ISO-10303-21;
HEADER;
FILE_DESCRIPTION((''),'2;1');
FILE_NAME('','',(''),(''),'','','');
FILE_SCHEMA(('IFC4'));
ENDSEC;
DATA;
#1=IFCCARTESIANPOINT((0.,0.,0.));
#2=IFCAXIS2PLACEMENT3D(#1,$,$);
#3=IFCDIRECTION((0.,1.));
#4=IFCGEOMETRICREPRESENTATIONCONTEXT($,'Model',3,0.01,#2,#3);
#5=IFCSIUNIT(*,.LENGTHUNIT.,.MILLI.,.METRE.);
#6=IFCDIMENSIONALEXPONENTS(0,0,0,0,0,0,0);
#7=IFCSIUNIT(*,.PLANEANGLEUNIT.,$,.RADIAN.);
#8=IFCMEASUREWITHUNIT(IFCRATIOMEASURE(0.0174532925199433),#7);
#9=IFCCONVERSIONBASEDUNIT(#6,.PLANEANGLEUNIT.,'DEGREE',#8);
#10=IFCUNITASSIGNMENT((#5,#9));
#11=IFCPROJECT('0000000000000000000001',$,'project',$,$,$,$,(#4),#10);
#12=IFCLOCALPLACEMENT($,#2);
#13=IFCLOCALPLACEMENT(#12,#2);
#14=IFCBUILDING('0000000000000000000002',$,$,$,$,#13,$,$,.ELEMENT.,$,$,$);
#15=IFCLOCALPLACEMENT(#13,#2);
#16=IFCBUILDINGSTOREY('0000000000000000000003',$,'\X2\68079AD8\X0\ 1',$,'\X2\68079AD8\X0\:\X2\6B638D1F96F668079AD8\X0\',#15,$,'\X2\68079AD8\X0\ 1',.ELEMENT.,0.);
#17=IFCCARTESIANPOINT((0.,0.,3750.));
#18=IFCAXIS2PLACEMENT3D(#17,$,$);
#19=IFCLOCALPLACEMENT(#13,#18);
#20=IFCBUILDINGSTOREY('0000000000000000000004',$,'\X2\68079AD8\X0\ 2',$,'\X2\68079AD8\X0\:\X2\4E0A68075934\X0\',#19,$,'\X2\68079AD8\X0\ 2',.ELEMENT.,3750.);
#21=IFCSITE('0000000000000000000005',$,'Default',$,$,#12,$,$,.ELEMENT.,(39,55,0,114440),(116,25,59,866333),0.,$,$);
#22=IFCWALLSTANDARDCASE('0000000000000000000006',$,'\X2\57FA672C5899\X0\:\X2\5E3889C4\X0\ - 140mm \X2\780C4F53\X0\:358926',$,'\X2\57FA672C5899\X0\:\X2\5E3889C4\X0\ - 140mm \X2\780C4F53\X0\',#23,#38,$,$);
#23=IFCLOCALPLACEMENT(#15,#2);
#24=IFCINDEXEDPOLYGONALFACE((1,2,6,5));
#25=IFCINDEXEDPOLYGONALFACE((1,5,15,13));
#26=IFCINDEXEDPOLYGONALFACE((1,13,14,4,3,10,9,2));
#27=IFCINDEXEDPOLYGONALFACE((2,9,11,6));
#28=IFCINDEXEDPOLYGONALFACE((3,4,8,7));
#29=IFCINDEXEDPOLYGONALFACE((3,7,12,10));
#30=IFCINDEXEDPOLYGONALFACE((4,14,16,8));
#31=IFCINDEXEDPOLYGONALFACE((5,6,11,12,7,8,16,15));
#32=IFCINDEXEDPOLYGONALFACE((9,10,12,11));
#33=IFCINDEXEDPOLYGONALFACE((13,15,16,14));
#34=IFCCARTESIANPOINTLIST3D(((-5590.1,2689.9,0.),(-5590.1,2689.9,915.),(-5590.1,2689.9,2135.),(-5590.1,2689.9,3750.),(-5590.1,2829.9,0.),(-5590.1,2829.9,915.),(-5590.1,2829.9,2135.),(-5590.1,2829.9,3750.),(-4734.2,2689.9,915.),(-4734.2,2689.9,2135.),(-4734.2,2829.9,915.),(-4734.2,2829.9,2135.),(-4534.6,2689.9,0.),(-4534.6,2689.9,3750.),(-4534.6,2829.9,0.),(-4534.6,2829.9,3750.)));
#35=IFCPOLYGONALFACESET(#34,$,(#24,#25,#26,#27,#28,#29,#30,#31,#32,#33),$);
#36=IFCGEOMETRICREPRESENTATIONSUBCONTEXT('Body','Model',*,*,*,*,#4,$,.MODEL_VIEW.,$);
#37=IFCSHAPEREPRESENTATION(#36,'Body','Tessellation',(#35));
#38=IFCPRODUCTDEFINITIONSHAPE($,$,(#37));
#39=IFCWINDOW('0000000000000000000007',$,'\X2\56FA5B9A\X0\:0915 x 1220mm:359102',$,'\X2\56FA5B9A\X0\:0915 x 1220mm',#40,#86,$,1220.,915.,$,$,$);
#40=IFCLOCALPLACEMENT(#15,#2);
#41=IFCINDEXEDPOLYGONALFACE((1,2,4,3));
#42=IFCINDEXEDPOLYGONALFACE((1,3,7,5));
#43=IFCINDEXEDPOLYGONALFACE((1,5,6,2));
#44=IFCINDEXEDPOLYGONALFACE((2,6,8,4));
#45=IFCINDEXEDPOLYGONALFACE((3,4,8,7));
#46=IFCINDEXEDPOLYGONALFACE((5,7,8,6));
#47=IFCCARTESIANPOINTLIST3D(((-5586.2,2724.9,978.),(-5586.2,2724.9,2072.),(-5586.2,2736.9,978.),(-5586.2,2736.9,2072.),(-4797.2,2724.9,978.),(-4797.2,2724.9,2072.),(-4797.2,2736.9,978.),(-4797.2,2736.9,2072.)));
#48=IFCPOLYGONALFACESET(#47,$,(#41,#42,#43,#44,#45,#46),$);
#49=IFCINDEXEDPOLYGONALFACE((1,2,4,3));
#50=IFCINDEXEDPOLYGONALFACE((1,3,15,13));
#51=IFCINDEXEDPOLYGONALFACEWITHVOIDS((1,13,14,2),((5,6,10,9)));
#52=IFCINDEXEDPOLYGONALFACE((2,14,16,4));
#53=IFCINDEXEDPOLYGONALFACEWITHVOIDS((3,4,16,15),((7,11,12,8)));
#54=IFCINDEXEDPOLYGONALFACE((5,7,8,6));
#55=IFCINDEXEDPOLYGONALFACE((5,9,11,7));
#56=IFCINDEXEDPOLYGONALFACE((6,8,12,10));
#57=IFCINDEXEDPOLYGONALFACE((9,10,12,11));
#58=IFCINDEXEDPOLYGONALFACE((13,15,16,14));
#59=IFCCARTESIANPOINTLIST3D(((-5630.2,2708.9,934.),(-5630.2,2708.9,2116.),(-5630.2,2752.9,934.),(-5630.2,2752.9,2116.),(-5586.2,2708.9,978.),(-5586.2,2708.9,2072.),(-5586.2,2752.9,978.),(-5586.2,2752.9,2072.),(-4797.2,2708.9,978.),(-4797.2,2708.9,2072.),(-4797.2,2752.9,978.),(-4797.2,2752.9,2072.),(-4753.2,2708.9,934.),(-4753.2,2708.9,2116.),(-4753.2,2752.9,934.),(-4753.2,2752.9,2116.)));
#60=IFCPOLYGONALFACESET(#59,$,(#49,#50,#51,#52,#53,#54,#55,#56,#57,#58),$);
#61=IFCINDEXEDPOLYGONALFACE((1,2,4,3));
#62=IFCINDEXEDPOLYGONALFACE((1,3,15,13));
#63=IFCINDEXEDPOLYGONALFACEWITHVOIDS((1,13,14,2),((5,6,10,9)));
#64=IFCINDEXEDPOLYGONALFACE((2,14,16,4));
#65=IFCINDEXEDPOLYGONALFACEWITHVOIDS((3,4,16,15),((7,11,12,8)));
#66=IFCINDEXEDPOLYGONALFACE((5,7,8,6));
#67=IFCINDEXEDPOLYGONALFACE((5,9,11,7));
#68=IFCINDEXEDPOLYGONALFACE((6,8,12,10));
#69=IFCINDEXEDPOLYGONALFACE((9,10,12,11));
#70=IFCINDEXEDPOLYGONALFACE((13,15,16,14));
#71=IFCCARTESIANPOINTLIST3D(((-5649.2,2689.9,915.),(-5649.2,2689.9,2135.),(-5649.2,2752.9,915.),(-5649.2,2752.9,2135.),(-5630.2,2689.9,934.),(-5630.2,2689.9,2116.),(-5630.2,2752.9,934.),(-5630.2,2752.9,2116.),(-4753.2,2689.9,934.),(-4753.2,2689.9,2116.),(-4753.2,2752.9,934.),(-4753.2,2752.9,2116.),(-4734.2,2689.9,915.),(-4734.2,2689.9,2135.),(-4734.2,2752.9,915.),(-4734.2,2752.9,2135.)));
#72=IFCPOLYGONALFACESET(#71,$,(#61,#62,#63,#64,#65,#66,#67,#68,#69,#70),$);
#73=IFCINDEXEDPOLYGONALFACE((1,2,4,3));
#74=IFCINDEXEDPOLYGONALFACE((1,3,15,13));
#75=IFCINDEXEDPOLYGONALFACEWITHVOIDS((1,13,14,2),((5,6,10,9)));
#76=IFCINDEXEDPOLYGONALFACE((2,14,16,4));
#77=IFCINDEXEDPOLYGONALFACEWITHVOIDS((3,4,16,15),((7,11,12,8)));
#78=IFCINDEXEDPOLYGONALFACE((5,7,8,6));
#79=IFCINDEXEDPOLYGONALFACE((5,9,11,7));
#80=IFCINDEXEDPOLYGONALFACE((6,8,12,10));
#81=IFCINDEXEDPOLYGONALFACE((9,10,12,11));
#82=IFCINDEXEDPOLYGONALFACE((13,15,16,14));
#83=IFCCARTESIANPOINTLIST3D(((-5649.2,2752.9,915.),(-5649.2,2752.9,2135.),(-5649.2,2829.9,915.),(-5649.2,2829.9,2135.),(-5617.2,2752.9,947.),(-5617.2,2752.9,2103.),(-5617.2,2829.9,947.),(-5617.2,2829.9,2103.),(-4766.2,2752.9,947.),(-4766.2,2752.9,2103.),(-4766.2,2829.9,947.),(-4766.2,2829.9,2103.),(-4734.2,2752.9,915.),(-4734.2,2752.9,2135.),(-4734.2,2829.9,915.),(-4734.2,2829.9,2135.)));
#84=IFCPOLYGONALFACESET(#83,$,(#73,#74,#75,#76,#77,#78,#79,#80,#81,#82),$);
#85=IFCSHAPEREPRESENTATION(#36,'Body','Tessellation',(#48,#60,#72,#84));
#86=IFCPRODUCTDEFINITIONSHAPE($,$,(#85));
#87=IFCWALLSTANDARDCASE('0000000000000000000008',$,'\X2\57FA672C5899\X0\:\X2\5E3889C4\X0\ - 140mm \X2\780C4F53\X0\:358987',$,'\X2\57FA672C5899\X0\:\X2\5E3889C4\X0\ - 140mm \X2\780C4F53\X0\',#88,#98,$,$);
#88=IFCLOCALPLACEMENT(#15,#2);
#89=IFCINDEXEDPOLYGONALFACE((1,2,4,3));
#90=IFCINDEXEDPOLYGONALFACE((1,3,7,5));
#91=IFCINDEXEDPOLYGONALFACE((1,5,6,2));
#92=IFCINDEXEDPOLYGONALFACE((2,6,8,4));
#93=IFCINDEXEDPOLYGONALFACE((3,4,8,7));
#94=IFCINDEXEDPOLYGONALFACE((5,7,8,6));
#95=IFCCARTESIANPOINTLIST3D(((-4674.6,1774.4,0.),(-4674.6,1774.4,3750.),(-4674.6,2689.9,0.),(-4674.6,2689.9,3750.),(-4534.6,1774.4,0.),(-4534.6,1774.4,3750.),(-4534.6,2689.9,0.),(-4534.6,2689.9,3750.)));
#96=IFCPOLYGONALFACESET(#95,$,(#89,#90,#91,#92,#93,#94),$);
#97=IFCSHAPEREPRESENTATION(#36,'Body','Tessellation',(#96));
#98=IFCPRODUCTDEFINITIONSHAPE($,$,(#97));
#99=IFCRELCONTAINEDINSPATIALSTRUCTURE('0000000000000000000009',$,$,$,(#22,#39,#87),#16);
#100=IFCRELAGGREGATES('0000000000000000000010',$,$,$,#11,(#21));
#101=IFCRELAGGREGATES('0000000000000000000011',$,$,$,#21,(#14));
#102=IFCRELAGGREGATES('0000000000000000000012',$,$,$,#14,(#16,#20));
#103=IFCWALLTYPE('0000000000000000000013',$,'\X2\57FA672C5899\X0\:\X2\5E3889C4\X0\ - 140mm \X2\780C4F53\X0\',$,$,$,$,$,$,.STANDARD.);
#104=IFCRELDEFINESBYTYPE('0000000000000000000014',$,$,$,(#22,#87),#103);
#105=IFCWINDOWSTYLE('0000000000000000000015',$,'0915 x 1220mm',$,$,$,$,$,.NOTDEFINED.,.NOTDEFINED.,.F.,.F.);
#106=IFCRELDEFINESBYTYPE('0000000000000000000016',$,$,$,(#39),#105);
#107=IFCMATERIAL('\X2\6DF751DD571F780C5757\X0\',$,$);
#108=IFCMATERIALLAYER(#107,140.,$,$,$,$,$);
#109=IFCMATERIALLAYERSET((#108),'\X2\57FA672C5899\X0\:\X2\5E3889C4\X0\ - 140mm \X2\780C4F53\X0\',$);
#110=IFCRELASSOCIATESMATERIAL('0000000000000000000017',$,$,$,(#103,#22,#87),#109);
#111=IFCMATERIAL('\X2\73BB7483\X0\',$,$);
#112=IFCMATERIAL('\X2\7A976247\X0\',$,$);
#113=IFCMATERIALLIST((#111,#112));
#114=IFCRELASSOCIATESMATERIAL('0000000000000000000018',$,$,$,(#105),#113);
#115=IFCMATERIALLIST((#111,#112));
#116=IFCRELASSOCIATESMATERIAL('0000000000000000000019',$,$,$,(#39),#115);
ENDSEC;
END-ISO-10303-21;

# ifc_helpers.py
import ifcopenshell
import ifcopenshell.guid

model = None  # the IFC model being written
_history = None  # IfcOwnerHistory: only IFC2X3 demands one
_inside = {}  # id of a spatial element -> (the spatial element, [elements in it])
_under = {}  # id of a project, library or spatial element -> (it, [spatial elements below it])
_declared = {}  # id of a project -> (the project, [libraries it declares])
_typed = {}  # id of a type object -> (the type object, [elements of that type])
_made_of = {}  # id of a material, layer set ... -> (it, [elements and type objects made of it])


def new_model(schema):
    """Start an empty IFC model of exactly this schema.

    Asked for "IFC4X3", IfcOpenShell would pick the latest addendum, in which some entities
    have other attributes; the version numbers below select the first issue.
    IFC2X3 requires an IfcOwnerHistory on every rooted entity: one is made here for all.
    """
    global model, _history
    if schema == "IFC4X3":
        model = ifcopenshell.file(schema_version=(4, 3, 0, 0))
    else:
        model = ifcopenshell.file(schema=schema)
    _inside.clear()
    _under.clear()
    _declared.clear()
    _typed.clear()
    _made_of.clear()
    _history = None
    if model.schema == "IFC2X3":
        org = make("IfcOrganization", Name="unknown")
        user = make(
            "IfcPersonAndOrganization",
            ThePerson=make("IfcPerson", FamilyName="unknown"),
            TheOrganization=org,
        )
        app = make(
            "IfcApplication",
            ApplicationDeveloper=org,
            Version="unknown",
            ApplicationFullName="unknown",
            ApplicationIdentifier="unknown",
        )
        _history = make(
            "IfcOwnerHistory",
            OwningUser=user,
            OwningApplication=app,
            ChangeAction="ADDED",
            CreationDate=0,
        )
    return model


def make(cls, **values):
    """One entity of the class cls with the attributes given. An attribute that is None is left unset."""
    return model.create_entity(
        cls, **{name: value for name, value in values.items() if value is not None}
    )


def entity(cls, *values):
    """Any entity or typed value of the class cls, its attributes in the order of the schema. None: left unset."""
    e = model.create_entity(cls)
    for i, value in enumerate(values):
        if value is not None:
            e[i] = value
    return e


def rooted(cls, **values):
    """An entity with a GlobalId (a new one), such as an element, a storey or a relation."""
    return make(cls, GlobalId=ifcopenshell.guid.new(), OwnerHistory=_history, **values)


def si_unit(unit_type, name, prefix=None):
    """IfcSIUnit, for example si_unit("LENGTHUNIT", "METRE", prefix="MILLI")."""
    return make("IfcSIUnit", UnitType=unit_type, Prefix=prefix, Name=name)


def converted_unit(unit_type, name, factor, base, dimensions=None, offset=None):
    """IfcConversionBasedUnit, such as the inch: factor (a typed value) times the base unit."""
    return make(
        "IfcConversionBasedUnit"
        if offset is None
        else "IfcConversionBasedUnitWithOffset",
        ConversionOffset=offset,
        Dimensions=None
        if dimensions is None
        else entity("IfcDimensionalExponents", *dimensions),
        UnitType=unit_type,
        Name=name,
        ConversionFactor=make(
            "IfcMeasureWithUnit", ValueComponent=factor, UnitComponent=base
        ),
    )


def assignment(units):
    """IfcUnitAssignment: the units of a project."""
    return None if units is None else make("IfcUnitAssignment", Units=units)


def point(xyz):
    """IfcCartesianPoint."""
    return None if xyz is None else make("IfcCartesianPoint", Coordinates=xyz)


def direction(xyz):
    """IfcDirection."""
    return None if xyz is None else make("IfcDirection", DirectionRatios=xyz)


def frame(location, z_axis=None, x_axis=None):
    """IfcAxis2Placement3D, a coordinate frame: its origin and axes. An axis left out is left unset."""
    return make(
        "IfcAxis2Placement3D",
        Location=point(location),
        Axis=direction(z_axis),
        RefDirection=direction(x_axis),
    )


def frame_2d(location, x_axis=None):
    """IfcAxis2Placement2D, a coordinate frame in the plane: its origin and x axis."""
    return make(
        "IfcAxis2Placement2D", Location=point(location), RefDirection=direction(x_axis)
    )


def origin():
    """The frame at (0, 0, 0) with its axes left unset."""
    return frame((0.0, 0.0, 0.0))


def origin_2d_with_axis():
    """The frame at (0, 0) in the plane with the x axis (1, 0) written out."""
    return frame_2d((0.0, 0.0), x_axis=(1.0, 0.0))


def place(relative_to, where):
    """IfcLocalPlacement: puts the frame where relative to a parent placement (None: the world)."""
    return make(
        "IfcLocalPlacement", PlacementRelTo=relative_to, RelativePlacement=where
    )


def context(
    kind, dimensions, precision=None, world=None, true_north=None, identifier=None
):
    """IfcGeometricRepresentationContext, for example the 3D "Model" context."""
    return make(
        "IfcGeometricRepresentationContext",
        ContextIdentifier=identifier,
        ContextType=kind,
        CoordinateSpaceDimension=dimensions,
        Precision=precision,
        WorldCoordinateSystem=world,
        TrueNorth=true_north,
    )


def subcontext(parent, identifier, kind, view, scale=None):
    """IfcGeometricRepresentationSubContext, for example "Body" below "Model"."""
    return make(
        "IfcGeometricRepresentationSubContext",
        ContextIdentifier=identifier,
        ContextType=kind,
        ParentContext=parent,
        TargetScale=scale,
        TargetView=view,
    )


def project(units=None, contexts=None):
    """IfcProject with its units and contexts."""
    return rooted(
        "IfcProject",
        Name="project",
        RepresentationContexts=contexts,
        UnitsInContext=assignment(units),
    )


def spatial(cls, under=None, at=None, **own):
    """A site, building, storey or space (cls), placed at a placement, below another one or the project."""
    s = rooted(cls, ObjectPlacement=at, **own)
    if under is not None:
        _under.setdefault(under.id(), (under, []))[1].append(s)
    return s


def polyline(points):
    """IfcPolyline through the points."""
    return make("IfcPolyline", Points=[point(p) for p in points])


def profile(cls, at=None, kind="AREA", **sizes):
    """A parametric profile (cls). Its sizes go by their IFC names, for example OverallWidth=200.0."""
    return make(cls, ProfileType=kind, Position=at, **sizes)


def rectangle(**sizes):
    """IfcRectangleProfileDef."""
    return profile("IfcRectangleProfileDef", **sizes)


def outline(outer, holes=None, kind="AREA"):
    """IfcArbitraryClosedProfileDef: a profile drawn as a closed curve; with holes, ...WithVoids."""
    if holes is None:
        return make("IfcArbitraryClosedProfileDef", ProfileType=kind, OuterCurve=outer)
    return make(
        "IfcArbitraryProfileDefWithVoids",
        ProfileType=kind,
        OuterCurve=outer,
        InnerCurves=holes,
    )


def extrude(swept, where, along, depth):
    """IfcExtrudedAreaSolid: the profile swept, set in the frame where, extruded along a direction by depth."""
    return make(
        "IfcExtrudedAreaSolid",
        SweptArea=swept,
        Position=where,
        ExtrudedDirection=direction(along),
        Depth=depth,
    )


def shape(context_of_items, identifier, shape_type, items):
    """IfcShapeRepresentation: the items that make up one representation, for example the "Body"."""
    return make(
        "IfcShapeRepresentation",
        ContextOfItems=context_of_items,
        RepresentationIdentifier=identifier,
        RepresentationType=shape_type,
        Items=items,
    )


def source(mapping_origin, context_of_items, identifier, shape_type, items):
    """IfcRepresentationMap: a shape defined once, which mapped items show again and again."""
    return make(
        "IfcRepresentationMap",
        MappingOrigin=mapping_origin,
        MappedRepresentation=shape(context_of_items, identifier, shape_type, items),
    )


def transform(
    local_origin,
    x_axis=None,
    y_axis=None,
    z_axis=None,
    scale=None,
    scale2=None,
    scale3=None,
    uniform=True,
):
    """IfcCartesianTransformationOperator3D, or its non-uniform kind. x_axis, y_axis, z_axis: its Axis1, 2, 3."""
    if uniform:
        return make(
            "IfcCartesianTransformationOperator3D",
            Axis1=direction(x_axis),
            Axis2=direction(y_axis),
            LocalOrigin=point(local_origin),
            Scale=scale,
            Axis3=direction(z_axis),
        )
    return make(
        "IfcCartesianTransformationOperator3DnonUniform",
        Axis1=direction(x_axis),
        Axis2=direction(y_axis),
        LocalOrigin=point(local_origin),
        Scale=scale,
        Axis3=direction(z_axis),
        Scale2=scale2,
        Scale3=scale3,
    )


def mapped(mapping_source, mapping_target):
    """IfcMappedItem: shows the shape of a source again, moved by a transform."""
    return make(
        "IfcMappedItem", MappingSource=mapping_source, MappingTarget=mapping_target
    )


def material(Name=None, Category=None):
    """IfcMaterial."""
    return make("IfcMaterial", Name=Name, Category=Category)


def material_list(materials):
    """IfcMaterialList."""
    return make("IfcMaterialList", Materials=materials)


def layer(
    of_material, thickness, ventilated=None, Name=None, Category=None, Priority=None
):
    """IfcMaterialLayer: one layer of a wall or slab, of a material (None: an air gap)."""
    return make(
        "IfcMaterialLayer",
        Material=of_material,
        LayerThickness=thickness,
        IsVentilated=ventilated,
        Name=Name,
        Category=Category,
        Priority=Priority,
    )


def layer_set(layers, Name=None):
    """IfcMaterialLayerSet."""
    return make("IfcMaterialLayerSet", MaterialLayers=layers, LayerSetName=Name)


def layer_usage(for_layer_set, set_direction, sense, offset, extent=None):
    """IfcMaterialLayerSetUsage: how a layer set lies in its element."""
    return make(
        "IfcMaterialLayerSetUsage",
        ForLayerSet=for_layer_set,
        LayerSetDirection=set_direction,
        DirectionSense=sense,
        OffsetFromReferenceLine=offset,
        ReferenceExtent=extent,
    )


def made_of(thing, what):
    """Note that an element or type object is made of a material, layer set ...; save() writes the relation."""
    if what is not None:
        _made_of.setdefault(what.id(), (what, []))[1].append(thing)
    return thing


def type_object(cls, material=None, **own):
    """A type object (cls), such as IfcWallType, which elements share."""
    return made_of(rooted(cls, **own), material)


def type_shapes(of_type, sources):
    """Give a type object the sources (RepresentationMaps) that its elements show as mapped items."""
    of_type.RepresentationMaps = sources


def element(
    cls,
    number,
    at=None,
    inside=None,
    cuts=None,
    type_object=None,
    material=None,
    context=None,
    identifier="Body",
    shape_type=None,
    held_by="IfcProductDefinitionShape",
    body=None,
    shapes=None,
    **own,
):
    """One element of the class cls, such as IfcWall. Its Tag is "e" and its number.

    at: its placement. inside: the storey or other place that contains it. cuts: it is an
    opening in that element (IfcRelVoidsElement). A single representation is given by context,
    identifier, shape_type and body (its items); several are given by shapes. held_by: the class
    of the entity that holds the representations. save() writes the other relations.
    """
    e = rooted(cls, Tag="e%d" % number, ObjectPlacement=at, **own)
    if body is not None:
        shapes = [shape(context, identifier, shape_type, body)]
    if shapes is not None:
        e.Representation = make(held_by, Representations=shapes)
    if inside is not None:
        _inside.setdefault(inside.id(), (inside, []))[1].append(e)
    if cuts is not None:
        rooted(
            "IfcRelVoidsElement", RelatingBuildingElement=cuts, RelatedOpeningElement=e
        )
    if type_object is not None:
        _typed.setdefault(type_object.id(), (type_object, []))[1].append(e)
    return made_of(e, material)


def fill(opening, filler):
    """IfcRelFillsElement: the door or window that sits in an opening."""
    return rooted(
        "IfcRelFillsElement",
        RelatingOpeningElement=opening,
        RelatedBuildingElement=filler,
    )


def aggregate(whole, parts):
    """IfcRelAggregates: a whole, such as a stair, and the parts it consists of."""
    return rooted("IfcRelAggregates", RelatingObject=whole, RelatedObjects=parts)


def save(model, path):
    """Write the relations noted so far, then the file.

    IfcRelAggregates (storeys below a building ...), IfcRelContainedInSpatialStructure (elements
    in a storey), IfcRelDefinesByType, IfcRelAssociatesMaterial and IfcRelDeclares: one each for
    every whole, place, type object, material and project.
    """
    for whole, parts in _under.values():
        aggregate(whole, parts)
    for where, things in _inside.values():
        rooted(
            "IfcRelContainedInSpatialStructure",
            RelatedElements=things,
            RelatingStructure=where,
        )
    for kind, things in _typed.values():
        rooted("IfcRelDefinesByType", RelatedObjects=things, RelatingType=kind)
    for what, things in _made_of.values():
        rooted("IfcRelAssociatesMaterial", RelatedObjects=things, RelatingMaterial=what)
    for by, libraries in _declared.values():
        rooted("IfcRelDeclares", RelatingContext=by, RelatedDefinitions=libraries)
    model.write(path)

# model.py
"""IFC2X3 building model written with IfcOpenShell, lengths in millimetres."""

from ifc_helpers import new_model, entity, si_unit, converted_unit, direction, frame, frame_2d, origin, origin_2d_with_axis, place, context, subcontext, project, spatial, polyline, rectangle, outline, extrude, source, transform, mapped, material, material_list, layer, layer_set, layer_usage, type_object, type_shapes, element, fill, save


model = new_model("IFC2X3")

# Units and contexts
model_context = context("Model", 3, precision=0.01, world=origin(), true_north=direction((0.0, 1.0)))
body_context = subcontext(model_context, "Body", "Model", "MODEL_VIEW")
ifc_project = project(units=[si_unit("LENGTHUNIT", "METRE", prefix="MILLI"), converted_unit("PLANEANGLEUNIT", "DEGREE", entity("IfcRatioMeasure", 0.0174532925199433), si_unit("PLANEANGLEUNIT", "RADIAN"), dimensions=[0, 0, 0, 0, 0, 0, 0])], contexts=[model_context])

# Site, building, storey
site_placement = place(None, origin())
site = spatial("IfcSite", under=ifc_project, at=site_placement, Name="Default", CompositionType="ELEMENT", RefLatitude=(39, 55, 0, 114440), RefLongitude=(116, 25, 59, 866333), RefElevation=0.0)
building_placement = place(site_placement, origin())
building = spatial("IfcBuilding", under=site, at=building_placement, CompositionType="ELEMENT")
storey_1_placement = place(building_placement, origin())
storey_1 = spatial("IfcBuildingStorey", under=building, at=storey_1_placement, Name="标高 1", ObjectType="标高:正负零标高", LongName="标高 1", CompositionType="ELEMENT", Elevation=0.0)

# Shared definitions
ifc_material_1 = material(Name="混凝土砌块")
ifc_layer_1 = layer(ifc_material_1, 140.0)
ifc_layer_set_1 = layer_set([ifc_layer_1], Name="基本墙:常规 - 140mm 砌体")
wall_type = type_object("IfcWallType", Name="基本墙:常规 - 140mm 砌体", PredefinedType="STANDARD", material=ifc_layer_set_1)

# Shared definitions
storey_2_placement = place(building_placement, frame((0.0, 0.0, 3750.0)))
storey_2 = spatial("IfcBuildingStorey", under=building, at=storey_2_placement, Name="标高 2", ObjectType="标高:上标头", LongName="标高 2", CompositionType="ELEMENT", Elevation=3750.0)

# Wall, opening, window
ifc_layer_usage_1 = layer_usage(ifc_layer_set_1, "AXIS2", "NEGATIVE", 70.0)
wall_1_placement = place(storey_1_placement, frame((-5590.1, 2759.9, 0.0)))
wall_1 = element("IfcWallStandardCase", 1, at=wall_1_placement, inside=storey_1, type_object=wall_type, material=ifc_layer_usage_1, Name="基本墙:常规 - 140mm 砌体:358926", ObjectType="基本墙:常规 - 140mm 砌体", context=body_context, shape_type="SweptSolid", body=[
    extrude(rectangle(XDim=1055.5, YDim=140.0, at=frame_2d((527.8, 0.0), x_axis=(-1.0, 0.0))), origin(), (0.0, 0.0, 1.0), 3750.0),
])
opening_1_placement = place(wall_1_placement, frame((855.9, 70.0, 915.0)))
opening_1 = element("IfcOpeningElement", 2, at=opening_1_placement, cuts=wall_1, ObjectType="Opening", context=body_context, shape_type="SweptSolid", body=[
    extrude(rectangle(XDim=1220.0, YDim=915.0, at=frame_2d((610.0, 457.5), x_axis=(1.0, 0.0))), frame((0.0, 0.0, 0.0), z_axis=(0.0, -1.0, 0.0), x_axis=(0.0, 0.0, 1.0)), (0.0, 0.0, 1.0), 140.0),
])
ifc_material_2 = material(Name="玻璃")
ifc_material_3 = material(Name="窗扇")
ifc_material_list_1 = material_list([ifc_material_2, ifc_material_3])
ifc_material_list_2 = material_list([ifc_material_2, ifc_material_3])
window_style = type_object("IfcWindowStyle", Name="0915 x 1220mm", ConstructionType="NOTDEFINED", OperationType="NOTDEFINED", ParameterTakesPrecedence=False, Sizeable=False, material=ifc_material_list_2)
shared_shape_1 = source(origin(), body_context, "Body", "SweptSolid", [
    extrude(rectangle(XDim=12.0, YDim=789.0, at=origin_2d_with_axis()), frame((457.5, 99.0, 63.0), z_axis=(0.0, 0.0, 1.0), x_axis=(0.0, -1.0, 0.0)), (0.0, 0.0, 1.0), 1094.0),
    extrude(outline(polyline([(-438.5, -591.0), (438.5, -591.0), (438.5, 591.0), (-438.5, 591.0), (-438.5, -591.0)]), holes=[polyline([(-394.5, -547.0), (-394.5, 547.0), (394.5, 547.0), (394.5, -547.0), (-394.5, -547.0)])]), frame((457.5, 77.0, 610.0), z_axis=(0.0, 1.0, 0.0), x_axis=(1.0, 0.0, 0.0)), (0.0, 0.0, 1.0), 44.0),
    extrude(outline(polyline([(-457.5, -610.0), (457.5, -610.0), (457.5, 610.0), (-457.5, 610.0), (-457.5, -610.0)]), holes=[polyline([(-438.5, -591.0), (-438.5, 591.0), (438.5, 591.0), (438.5, -591.0), (-438.5, -591.0)])]), frame((457.5, 77.0, 610.0), z_axis=(0.0, 1.0, 0.0), x_axis=(1.0, 0.0, 0.0)), (0.0, 0.0, 1.0), 63.0),
    extrude(outline(polyline([(-457.5, -610.0), (457.5, -610.0), (457.5, 610.0), (-457.5, 610.0), (-457.5, -610.0)]), holes=[polyline([(-425.5, -578.0), (-425.5, 578.0), (425.5, 578.0), (425.5, -578.0), (-425.5, -578.0)])]), frame((457.5, 0.0, 610.0), z_axis=(0.0, 1.0, 0.0), x_axis=(1.0, 0.0, 0.0)), (0.0, 0.0, 1.0), 77.0),
])
type_shapes(window_style, [shared_shape_1])
window_placement = place(opening_1_placement, frame((0.0, 0.0, 0.0), z_axis=(0.0, 0.0, 1.0), x_axis=(-1.0, 0.0, 0.0)))
window = element("IfcWindow", 3, at=window_placement, inside=storey_1, type_object=window_style, material=ifc_material_list_1, Name="固定:0915 x 1220mm:359102", ObjectType="固定:0915 x 1220mm", OverallHeight=1220.0, OverallWidth=915.0, context=body_context, shape_type="MappedRepresentation", body=[
    mapped(shared_shape_1, transform((0.0, 0.0, 0.0), scale=1.0)),
])
fill(opening_1, window)

# Wall
ifc_layer_usage_2 = layer_usage(ifc_layer_set_1, "AXIS2", "NEGATIVE", 70.0)
wall_2_placement = place(storey_1_placement, frame((-4604.6, 2689.9, 0.0), z_axis=(0.0, 0.0, 1.0), x_axis=(0.0, -1.0, 0.0)))
element("IfcWallStandardCase", 4, at=wall_2_placement, inside=storey_1, type_object=wall_type, material=ifc_layer_usage_2, Name="基本墙:常规 - 140mm 砌体:358987", ObjectType="基本墙:常规 - 140mm 砌体", context=body_context, shape_type="SweptSolid", body=[
    extrude(rectangle(XDim=915.5, YDim=140.0, at=frame_2d((457.8, 0.0), x_axis=(-1.0, 0.0))), origin(), (0.0, 0.0, 1.0), 3750.0),
])

save(model, "model.ifc")
